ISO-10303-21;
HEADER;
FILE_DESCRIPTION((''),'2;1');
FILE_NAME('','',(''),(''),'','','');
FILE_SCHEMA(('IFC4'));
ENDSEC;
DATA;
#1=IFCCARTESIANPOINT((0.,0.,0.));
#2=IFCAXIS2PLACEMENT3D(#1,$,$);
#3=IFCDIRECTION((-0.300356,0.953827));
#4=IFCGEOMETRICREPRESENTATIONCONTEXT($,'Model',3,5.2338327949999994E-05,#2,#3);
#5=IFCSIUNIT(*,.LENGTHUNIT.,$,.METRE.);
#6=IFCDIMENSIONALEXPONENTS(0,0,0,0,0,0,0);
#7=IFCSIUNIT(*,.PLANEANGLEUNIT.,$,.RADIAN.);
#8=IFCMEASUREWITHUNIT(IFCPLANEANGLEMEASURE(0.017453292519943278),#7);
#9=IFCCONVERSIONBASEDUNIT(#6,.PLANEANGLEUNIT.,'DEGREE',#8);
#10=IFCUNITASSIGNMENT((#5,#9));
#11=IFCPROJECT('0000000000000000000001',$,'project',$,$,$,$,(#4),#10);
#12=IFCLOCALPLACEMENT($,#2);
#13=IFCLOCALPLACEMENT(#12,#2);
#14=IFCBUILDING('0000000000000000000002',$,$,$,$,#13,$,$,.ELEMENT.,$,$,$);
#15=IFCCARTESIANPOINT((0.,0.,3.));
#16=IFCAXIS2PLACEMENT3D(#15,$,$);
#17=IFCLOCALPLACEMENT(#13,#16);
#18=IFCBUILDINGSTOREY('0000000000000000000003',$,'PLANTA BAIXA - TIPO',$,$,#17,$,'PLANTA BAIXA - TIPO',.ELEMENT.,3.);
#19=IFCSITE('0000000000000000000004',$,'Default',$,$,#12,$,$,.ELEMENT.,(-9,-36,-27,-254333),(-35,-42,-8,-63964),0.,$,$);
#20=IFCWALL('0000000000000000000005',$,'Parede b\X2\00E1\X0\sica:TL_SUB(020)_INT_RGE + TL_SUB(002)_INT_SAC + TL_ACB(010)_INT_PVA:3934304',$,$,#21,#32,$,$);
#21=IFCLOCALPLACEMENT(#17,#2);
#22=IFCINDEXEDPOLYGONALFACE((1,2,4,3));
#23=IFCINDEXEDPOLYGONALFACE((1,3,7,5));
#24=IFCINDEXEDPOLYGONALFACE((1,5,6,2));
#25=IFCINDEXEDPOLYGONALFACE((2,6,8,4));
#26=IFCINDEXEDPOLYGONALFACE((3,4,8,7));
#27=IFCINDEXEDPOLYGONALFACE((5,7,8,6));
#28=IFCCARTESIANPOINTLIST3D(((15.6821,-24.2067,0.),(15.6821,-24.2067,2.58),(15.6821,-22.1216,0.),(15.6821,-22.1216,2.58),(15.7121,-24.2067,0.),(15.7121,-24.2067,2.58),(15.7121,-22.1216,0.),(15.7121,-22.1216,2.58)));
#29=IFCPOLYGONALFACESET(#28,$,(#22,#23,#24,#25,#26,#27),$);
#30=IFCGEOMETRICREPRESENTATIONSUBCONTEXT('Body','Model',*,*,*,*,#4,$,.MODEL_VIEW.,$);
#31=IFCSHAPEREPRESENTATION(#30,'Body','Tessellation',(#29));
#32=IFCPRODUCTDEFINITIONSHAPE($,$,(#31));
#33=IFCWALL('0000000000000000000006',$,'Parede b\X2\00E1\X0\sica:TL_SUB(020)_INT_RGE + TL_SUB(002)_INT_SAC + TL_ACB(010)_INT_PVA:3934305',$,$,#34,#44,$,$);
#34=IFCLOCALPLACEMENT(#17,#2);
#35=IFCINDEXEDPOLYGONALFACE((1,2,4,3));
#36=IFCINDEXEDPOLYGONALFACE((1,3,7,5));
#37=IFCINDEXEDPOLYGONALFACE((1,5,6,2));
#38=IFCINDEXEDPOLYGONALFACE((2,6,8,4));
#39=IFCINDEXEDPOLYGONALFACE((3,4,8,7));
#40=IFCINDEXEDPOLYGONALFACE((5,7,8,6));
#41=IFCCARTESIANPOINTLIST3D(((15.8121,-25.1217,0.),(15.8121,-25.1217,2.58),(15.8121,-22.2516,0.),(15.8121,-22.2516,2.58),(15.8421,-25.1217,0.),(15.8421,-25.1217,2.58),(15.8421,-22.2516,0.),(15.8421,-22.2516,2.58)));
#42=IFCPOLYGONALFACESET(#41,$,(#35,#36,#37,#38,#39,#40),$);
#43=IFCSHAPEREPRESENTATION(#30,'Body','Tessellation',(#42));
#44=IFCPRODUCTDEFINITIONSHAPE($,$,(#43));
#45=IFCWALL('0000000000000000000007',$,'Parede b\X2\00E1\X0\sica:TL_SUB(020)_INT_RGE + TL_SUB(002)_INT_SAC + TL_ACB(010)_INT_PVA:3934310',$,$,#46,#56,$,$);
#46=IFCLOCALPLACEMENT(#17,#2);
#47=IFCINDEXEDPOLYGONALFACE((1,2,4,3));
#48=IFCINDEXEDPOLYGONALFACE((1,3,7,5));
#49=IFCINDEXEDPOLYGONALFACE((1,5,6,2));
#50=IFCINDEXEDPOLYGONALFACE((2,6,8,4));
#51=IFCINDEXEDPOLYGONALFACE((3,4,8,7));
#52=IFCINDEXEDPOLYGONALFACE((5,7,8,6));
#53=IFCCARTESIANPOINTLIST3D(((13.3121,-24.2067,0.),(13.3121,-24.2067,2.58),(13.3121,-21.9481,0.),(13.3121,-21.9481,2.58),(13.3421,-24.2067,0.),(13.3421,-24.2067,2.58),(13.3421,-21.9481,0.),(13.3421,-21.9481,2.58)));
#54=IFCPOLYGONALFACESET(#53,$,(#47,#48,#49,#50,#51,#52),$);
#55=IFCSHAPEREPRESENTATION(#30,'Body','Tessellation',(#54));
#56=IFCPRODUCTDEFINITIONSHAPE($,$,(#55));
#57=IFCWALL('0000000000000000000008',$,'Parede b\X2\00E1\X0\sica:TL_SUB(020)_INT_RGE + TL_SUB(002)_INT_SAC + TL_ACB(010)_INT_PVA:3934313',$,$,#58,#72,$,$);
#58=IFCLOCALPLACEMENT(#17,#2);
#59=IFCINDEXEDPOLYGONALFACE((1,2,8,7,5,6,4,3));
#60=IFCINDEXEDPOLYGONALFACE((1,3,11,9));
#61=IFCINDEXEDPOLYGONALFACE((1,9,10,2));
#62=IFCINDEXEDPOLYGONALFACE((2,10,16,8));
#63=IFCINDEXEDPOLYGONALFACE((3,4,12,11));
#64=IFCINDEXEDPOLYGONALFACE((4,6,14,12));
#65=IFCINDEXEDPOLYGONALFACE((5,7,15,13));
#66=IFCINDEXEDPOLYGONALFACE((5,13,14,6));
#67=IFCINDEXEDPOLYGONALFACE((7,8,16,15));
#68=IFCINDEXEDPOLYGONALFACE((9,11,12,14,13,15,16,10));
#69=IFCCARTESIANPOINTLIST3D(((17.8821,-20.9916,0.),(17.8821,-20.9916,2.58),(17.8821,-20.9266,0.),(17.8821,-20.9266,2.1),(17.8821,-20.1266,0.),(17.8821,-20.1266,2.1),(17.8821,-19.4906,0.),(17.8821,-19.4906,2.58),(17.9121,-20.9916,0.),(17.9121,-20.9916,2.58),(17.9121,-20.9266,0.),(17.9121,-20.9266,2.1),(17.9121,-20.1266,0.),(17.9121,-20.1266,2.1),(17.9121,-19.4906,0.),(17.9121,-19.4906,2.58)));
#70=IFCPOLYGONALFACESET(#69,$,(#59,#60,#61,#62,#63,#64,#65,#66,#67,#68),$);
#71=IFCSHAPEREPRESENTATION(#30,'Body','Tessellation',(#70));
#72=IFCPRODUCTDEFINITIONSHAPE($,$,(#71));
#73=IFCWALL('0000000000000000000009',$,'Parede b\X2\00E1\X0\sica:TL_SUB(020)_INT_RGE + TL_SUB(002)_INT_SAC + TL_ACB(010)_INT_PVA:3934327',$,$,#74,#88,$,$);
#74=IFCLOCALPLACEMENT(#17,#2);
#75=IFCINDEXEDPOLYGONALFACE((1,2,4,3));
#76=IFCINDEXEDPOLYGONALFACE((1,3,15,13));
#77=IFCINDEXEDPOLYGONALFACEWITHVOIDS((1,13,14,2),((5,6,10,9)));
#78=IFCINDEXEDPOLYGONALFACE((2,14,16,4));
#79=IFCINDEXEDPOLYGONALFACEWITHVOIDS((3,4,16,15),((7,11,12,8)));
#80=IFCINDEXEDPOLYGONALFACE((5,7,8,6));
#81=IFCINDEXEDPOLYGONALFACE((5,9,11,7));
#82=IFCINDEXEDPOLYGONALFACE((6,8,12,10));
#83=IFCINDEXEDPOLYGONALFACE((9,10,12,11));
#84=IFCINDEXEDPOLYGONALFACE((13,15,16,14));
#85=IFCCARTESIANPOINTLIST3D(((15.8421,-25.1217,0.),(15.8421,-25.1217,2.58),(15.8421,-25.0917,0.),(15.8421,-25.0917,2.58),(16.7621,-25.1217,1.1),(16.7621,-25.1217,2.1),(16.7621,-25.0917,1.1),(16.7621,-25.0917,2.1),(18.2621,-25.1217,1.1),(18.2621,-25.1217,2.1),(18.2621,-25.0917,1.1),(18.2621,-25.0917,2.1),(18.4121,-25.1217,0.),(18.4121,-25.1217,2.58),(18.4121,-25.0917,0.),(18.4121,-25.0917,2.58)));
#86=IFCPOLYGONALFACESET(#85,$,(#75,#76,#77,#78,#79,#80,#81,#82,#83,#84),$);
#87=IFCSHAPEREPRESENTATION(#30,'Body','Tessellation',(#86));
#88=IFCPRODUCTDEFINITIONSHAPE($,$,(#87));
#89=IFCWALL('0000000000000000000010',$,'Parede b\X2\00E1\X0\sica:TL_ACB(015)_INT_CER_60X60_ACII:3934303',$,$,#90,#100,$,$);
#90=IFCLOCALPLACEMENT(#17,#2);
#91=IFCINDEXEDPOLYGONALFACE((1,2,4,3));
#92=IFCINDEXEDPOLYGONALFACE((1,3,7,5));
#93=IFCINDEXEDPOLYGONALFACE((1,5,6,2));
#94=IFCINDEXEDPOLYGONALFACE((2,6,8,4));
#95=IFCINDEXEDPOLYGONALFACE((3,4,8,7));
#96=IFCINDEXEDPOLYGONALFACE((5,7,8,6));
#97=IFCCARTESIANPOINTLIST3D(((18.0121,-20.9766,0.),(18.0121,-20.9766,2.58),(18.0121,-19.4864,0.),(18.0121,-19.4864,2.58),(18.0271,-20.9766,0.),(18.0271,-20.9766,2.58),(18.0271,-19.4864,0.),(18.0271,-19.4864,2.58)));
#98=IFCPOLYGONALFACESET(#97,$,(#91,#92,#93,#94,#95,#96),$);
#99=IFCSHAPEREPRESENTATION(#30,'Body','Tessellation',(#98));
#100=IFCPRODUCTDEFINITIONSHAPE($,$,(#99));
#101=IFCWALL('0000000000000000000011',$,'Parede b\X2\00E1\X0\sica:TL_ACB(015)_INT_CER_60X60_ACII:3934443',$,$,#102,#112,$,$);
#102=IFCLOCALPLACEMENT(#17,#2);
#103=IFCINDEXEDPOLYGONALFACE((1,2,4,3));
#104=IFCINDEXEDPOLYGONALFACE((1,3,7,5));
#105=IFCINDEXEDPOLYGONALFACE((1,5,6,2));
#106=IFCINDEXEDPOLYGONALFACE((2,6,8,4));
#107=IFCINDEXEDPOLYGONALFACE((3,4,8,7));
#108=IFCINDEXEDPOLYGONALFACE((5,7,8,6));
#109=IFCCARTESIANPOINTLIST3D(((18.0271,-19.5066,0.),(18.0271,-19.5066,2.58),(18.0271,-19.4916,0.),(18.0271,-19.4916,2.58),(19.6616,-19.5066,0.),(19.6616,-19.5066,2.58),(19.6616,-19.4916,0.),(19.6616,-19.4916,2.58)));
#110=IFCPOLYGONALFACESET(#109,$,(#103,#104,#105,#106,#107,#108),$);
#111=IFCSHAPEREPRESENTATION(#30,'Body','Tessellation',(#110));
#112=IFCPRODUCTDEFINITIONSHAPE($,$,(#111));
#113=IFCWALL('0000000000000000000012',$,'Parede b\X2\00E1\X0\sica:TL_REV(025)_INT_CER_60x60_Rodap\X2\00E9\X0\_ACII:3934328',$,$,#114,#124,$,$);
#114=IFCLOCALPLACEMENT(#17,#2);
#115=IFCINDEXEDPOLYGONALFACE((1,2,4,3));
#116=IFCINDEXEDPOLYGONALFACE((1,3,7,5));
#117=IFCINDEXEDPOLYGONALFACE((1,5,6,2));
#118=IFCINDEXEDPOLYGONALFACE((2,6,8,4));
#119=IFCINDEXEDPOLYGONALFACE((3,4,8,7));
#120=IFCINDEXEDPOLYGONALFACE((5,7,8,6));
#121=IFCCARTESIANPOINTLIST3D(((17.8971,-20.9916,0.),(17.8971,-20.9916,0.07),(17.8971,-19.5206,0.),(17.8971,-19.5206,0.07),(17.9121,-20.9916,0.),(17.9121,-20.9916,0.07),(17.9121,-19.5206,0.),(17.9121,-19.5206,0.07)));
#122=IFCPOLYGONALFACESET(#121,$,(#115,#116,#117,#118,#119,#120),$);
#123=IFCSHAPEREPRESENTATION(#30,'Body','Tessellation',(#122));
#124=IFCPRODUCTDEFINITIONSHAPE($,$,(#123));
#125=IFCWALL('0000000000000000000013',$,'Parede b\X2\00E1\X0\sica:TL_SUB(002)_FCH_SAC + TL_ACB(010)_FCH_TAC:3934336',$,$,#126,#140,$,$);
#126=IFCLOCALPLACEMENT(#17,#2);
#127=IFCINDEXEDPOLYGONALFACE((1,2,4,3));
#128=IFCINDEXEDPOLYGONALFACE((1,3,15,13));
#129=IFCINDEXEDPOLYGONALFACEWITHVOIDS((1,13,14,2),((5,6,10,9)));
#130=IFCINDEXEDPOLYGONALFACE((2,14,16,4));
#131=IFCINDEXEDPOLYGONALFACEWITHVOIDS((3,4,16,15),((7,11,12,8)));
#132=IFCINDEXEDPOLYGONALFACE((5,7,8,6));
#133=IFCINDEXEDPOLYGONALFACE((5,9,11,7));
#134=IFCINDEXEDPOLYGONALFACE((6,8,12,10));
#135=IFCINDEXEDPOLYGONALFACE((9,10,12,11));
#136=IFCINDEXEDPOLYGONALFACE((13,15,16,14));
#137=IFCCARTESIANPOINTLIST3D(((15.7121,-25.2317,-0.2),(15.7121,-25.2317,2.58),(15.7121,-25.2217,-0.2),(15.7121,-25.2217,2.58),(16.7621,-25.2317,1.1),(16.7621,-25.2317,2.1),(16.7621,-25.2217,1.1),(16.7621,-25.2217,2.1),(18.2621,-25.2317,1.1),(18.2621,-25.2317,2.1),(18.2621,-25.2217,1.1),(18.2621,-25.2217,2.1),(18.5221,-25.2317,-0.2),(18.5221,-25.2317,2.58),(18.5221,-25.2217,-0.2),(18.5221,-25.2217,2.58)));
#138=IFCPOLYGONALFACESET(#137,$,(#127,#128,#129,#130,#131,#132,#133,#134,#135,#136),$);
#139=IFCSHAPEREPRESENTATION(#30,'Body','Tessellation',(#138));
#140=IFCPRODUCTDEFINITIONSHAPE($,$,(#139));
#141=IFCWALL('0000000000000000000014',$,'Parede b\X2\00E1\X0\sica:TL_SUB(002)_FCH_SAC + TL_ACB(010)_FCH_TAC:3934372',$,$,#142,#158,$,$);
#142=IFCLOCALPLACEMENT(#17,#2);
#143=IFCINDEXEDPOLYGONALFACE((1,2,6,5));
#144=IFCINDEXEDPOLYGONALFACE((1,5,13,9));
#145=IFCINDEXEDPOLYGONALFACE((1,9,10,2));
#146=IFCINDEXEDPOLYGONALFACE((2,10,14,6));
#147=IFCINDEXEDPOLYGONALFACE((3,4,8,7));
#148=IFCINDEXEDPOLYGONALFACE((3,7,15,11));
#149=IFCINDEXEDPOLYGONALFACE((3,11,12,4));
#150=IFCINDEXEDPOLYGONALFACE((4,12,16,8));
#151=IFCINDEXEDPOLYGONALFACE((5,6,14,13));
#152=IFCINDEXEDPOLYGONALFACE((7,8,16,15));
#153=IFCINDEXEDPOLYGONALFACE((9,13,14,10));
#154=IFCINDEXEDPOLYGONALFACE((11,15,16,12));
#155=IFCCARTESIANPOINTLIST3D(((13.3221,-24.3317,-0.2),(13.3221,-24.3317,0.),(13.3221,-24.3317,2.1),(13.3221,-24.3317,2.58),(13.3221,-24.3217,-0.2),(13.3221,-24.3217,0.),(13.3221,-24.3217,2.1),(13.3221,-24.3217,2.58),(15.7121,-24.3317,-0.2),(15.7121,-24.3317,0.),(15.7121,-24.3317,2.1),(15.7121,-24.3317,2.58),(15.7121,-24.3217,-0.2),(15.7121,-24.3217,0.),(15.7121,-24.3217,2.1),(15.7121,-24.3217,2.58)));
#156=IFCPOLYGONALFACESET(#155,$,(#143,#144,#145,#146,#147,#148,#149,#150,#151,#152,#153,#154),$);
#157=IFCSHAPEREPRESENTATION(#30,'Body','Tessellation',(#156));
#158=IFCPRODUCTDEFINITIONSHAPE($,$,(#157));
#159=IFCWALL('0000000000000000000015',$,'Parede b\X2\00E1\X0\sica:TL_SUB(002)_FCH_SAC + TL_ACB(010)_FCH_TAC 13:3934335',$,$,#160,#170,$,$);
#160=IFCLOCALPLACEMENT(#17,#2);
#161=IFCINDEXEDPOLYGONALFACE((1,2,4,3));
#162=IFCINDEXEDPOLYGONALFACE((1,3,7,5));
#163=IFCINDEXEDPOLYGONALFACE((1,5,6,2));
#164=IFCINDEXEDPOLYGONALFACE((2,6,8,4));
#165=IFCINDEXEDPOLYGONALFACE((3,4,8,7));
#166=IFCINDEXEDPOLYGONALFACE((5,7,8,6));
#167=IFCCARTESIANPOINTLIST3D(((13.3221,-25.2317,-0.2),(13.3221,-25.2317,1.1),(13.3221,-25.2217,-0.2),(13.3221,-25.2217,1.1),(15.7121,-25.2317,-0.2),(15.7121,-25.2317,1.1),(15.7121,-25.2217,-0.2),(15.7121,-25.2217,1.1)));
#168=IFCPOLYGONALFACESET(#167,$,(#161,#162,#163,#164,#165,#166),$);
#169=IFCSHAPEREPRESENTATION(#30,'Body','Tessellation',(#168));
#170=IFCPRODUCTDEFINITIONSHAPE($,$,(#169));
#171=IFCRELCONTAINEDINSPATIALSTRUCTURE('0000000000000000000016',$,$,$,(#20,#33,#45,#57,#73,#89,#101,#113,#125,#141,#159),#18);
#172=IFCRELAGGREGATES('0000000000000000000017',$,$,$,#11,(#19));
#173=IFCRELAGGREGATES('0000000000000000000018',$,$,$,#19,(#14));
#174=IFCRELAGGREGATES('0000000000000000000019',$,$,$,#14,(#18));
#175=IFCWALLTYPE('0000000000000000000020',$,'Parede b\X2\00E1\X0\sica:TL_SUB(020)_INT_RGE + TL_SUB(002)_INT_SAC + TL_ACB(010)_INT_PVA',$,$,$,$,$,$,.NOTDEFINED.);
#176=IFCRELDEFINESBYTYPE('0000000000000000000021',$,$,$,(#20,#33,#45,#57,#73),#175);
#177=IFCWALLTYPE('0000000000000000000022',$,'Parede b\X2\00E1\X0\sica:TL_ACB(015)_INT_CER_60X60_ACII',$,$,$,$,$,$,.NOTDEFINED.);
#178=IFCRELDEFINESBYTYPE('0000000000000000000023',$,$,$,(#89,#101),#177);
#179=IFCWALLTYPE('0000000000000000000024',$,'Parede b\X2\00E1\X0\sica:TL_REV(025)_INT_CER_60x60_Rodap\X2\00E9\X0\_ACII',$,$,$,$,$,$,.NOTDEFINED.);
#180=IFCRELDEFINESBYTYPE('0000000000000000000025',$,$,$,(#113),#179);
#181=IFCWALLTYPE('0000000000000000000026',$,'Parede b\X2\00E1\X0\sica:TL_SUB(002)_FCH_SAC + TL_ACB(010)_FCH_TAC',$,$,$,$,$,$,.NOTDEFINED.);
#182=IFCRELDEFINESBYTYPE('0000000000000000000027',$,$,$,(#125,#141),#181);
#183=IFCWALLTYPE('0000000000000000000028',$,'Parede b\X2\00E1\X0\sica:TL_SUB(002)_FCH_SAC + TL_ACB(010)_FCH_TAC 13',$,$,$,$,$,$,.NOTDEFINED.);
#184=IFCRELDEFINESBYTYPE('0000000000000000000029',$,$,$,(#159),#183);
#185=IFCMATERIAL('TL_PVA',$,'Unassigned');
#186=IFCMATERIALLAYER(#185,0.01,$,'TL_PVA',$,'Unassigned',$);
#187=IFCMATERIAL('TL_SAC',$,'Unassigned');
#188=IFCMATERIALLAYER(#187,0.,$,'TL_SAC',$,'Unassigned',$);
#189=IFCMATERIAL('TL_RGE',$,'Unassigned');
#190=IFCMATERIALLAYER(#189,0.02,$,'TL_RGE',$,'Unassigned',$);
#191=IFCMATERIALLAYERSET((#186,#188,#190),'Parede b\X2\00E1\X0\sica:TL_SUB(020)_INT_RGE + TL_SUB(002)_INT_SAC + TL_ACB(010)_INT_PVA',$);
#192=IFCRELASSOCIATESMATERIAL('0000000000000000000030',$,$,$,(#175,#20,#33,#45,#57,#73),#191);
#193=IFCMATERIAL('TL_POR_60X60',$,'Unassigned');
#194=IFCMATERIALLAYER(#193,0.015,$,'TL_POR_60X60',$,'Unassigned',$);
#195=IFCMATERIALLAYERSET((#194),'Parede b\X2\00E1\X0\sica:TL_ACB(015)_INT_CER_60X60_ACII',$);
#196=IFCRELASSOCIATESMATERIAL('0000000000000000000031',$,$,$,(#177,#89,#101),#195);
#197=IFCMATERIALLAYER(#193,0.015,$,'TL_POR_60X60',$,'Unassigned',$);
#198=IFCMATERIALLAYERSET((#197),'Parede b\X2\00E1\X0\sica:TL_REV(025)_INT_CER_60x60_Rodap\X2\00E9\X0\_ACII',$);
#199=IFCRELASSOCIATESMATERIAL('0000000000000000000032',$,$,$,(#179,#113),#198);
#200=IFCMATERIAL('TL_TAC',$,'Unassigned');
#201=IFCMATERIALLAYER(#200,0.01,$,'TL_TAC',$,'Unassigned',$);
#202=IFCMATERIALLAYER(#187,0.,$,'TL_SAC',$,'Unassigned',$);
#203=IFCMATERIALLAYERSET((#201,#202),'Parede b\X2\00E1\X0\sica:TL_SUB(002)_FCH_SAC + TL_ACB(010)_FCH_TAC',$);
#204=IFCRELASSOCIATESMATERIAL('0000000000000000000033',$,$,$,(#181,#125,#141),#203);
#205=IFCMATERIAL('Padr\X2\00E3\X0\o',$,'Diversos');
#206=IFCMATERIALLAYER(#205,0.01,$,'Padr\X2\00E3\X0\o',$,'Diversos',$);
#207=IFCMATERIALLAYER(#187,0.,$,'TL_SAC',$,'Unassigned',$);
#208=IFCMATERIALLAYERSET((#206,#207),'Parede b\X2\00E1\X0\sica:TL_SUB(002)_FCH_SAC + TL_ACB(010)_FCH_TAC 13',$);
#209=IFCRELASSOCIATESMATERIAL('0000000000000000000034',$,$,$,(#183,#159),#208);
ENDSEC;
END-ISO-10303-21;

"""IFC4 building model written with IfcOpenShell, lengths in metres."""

from ifc_helpers import new_model, entity, si_unit, converted_unit, direction, frame, frame_2d, origin, place, context, subcontext, project, spatial, rectangle, extrude, material, layer, layer_set, layer_usage, type_object, element, save


model = new_model("IFC4")

# Units and contexts
model_context = context("Model", 3, precision=5.2338327949999994e-05, world=origin(), true_north=direction((-0.300356, 0.953827)))
body_context = subcontext(model_context, "Body", "Model", "MODEL_VIEW")
ifc_project = project(units=[si_unit("LENGTHUNIT", "METRE"), converted_unit("PLANEANGLEUNIT", "DEGREE", entity("IfcPlaneAngleMeasure", 0.017453292519943278), si_unit("PLANEANGLEUNIT", "RADIAN"), dimensions=[0, 0, 0, 0, 0, 0, 0])], contexts=[model_context])

# Site, building, storey
site_placement = place(None, origin())
site = spatial("IfcSite", under=ifc_project, at=site_placement, Name="Default", CompositionType="ELEMENT", RefLatitude=(-9, -36, -27, -254333), RefLongitude=(-35, -42, -8, -63964), RefElevation=0.0)
building_placement = place(site_placement, origin())
building = spatial("IfcBuilding", under=site, at=building_placement, CompositionType="ELEMENT")
storey_placement = place(building_placement, frame((0.0, 0.0, 3.0)))
storey = spatial("IfcBuildingStorey", under=building, at=storey_placement, Name="PLANTA BAIXA - TIPO", LongName="PLANTA BAIXA - TIPO", CompositionType="ELEMENT", Elevation=3.0)

# Shared definitions
ifc_material_1 = material(Name="TL_PVA", Category="Unassigned")
ifc_layer_1 = layer(ifc_material_1, 0.01, Name="TL_PVA", Category="Unassigned")
ifc_material_2 = material(Name="TL_SAC", Category="Unassigned")
ifc_layer_2 = layer(ifc_material_2, 0.0, Name="TL_SAC", Category="Unassigned")
ifc_material_3 = material(Name="TL_RGE", Category="Unassigned")
ifc_layer_3 = layer(ifc_material_3, 0.02, Name="TL_RGE", Category="Unassigned")
ifc_layer_set_1 = layer_set([ifc_layer_1, ifc_layer_2, ifc_layer_3], Name="Parede básica:TL_SUB(020)_INT_RGE + TL_SUB(002)_INT_SAC + TL_ACB(010)_INT_PVA")
wall_type_1 = type_object("IfcWallType", Name="Parede básica:TL_SUB(020)_INT_RGE + TL_SUB(002)_INT_SAC + TL_ACB(010)_INT_PVA", PredefinedType="NOTDEFINED", material=ifc_layer_set_1)

# Walls
ifc_layer_usage_1 = layer_usage(ifc_layer_set_1, "AXIS2", "NEGATIVE", 0.015)
wall_1_placement = place(storey_placement, frame((15.6971, -24.2067, 0.0), z_axis=(0.0, 0.0, 1.0), x_axis=(0.0, 1.0, 0.0)))
element("IfcWall", 1, at=wall_1_placement, inside=storey, type_object=wall_type_1, material=ifc_layer_usage_1, Name="Parede básica:TL_SUB(020)_INT_RGE + TL_SUB(002)_INT_SAC + TL_ACB(010)_INT_PVA:3934304", context=body_context, shape_type="SweptSolid", body=[
    extrude(rectangle(XDim=2.0851, YDim=0.03, at=frame_2d((1.0426, 0.0), x_axis=(-1.0, 0.0))), origin(), (0.0, 0.0, 1.0), 2.58),
])
ifc_layer_usage_2 = layer_usage(ifc_layer_set_1, "AXIS2", "NEGATIVE", 0.015)
wall_2_placement = place(storey_placement, frame((15.8271, -22.2516, 0.0), z_axis=(0.0, 0.0, 1.0), x_axis=(0.0, -1.0, 0.0)))
element("IfcWall", 2, at=wall_2_placement, inside=storey, type_object=wall_type_1, material=ifc_layer_usage_2, Name="Parede básica:TL_SUB(020)_INT_RGE + TL_SUB(002)_INT_SAC + TL_ACB(010)_INT_PVA:3934305", context=body_context, shape_type="SweptSolid", body=[
    extrude(rectangle(XDim=2.8701, YDim=0.03, at=frame_2d((1.4351, 0.0), x_axis=(-1.0, 0.0))), origin(), (0.0, 0.0, 1.0), 2.58),
])
ifc_layer_usage_3 = layer_usage(ifc_layer_set_1, "AXIS2", "NEGATIVE", 0.015)
wall_3_placement = place(storey_placement, frame((13.3271, -21.9481, 0.0), z_axis=(0.0, 0.0, 1.0), x_axis=(0.0, -1.0, 0.0)))
element("IfcWall", 3, at=wall_3_placement, inside=storey, type_object=wall_type_1, material=ifc_layer_usage_3, Name="Parede básica:TL_SUB(020)_INT_RGE + TL_SUB(002)_INT_SAC + TL_ACB(010)_INT_PVA:3934310", context=body_context, shape_type="SweptSolid", body=[
    extrude(rectangle(XDim=2.2587, YDim=0.03, at=frame_2d((1.1293, 0.0), x_axis=(-1.0, 0.0))), origin(), (0.0, 0.0, 1.0), 2.58),
])

# Walls, openings
ifc_layer_usage_4 = layer_usage(ifc_layer_set_1, "AXIS2", "NEGATIVE", 0.015)
wall_4_placement = place(storey_placement, frame((17.8971, -20.9916, 0.0), z_axis=(0.0, 0.0, 1.0), x_axis=(0.0, 1.0, 0.0)))
wall_4 = element("IfcWall", 4, at=wall_4_placement, inside=storey, type_object=wall_type_1, material=ifc_layer_usage_4, Name="Parede básica:TL_SUB(020)_INT_RGE + TL_SUB(002)_INT_SAC + TL_ACB(010)_INT_PVA:3934313", context=body_context, shape_type="SweptSolid", body=[
    extrude(rectangle(XDim=1.501, YDim=0.03, at=frame_2d((0.7505, 0.0), x_axis=(-1.0, 0.0))), origin(), (0.0, 0.0, 1.0), 2.58),
])
opening_1_placement = place(wall_4_placement, frame((0.865, 0.015, 0.0)))
element("IfcOpeningElement", 5, at=opening_1_placement, cuts=wall_4, PredefinedType="OPENING", context=body_context, shape_type="SweptSolid", body=[
    extrude(rectangle(XDim=2.1, YDim=0.8, at=frame_2d((1.05, 0.4), x_axis=(1.0, 0.0))), frame((0.0, 0.0, 0.0), z_axis=(0.0, -1.0, 0.0), x_axis=(0.0, 0.0, 1.0)), (0.0, 0.0, 1.0), 0.03),
])
ifc_layer_usage_5 = layer_usage(ifc_layer_set_1, "AXIS2", "NEGATIVE", 0.015)
wall_5_placement = place(storey_placement, frame((15.8421, -25.1067, 0.0)))
wall_5 = element("IfcWall", 6, at=wall_5_placement, inside=storey, type_object=wall_type_1, material=ifc_layer_usage_5, Name="Parede básica:TL_SUB(020)_INT_RGE + TL_SUB(002)_INT_SAC + TL_ACB(010)_INT_PVA:3934327", context=body_context, shape_type="SweptSolid", body=[
    extrude(rectangle(XDim=2.57, YDim=0.03, at=frame_2d((1.285, 0.0), x_axis=(-1.0, 0.0))), origin(), (0.0, 0.0, 1.0), 2.58),
])
opening_2_placement = place(wall_5_placement, frame((-15.8421, 25.1067, 1.1)))
element("IfcOpeningElement", 7, at=opening_2_placement, cuts=wall_5, PredefinedType="OPENING", context=body_context, shape_type="SweptSolid", body=[
    extrude(rectangle(XDim=1.0, YDim=1.5, at=frame_2d((0.0, 0.0), x_axis=(0.0, 1.0))), frame((17.5121, -26.6457, 0.5), z_axis=(0.0, 1.0, 0.0), x_axis=(1.0, 0.0, 0.0)), (0.0, 0.0, 1.0), 3.048),
])

# Walls
ifc_material_4 = material(Name="TL_POR_60X60", Category="Unassigned")
ifc_layer_4 = layer(ifc_material_4, 0.015, Name="TL_POR_60X60", Category="Unassigned")
ifc_layer_set_2 = layer_set([ifc_layer_4], Name="Parede básica:TL_ACB(015)_INT_CER_60X60_ACII")
ifc_layer_usage_6 = layer_usage(ifc_layer_set_2, "AXIS2", "NEGATIVE", 0.0075)
wall_type_2 = type_object("IfcWallType", Name="Parede básica:TL_ACB(015)_INT_CER_60X60_ACII", PredefinedType="NOTDEFINED", material=ifc_layer_set_2)
wall_6_placement = place(storey_placement, frame((18.0196, -19.4864, 0.0), z_axis=(0.0, 0.0, 1.0), x_axis=(0.0, -1.0, 0.0)))
element("IfcWall", 8, at=wall_6_placement, inside=storey, type_object=wall_type_2, material=ifc_layer_usage_6, Name="Parede básica:TL_ACB(015)_INT_CER_60X60_ACII:3934303", context=body_context, shape_type="SweptSolid", body=[
    extrude(rectangle(XDim=1.4902, YDim=0.015, at=frame_2d((0.7451, 0.0), x_axis=(-1.0, 0.0))), origin(), (0.0, 0.0, 1.0), 2.58),
])
ifc_layer_usage_7 = layer_usage(ifc_layer_set_2, "AXIS2", "POSITIVE", -0.0075)
wall_7_placement = place(storey_placement, frame((18.0271, -19.4991, 0.0)))
element("IfcWall", 9, at=wall_7_placement, inside=storey, type_object=wall_type_2, material=ifc_layer_usage_7, Name="Parede básica:TL_ACB(015)_INT_CER_60X60_ACII:3934443", context=body_context, shape_type="SweptSolid", body=[
    extrude(rectangle(XDim=1.6345, YDim=0.015, at=frame_2d((0.8172, 0.0), x_axis=(-1.0, 0.0))), origin(), (0.0, 0.0, 1.0), 2.58),
])
ifc_layer_5 = layer(ifc_material_4, 0.015, Name="TL_POR_60X60", Category="Unassigned")
ifc_layer_set_3 = layer_set([ifc_layer_5], Name="Parede básica:TL_REV(025)_INT_CER_60x60_Rodapé_ACII")
ifc_layer_usage_8 = layer_usage(ifc_layer_set_3, "AXIS2", "POSITIVE", -0.0075)
wall_type_3 = type_object("IfcWallType", Name="Parede básica:TL_REV(025)_INT_CER_60x60_Rodapé_ACII", PredefinedType="NOTDEFINED", material=ifc_layer_set_3)
wall_8_placement = place(storey_placement, frame((17.9046, -19.5206, 0.0), z_axis=(0.0, 0.0, 1.0), x_axis=(0.0, -1.0, 0.0)))
element("IfcWall", 10, at=wall_8_placement, inside=storey, type_object=wall_type_3, material=ifc_layer_usage_8, Name="Parede básica:TL_REV(025)_INT_CER_60x60_Rodapé_ACII:3934328", context=body_context, shape_type="SweptSolid", body=[
    extrude(rectangle(XDim=1.471, YDim=0.015, at=frame_2d((0.7355, 0.0), x_axis=(-1.0, 0.0))), origin(), (0.0, 0.0, 1.0), 0.07),
])

# Walls, openings
ifc_material_5 = material(Name="TL_TAC", Category="Unassigned")
ifc_layer_6 = layer(ifc_material_5, 0.01, Name="TL_TAC", Category="Unassigned")
ifc_layer_7 = layer(ifc_material_2, 0.0, Name="TL_SAC", Category="Unassigned")
ifc_layer_set_4 = layer_set([ifc_layer_6, ifc_layer_7], Name="Parede básica:TL_SUB(002)_FCH_SAC + TL_ACB(010)_FCH_TAC")
ifc_layer_usage_9 = layer_usage(ifc_layer_set_4, "AXIS2", "POSITIVE", -0.005)
wall_type_4 = type_object("IfcWallType", Name="Parede básica:TL_SUB(002)_FCH_SAC + TL_ACB(010)_FCH_TAC", PredefinedType="NOTDEFINED", material=ifc_layer_set_4)
wall_9_placement = place(storey_placement, frame((15.7121, -25.2267, -0.2)))
wall_9 = element("IfcWall", 11, at=wall_9_placement, inside=storey, type_object=wall_type_4, material=ifc_layer_usage_9, Name="Parede básica:TL_SUB(002)_FCH_SAC + TL_ACB(010)_FCH_TAC:3934336", context=body_context, shape_type="SweptSolid", body=[
    extrude(rectangle(XDim=2.81, YDim=0.01, at=frame_2d((1.405, 0.0), x_axis=(-1.0, 0.0))), origin(), (0.0, 0.0, 1.0), 2.78),
])
opening_3_placement = place(wall_9_placement, frame((-15.7121, 25.2267, 1.3)))
element("IfcOpeningElement", 12, at=opening_3_placement, cuts=wall_9, PredefinedType="OPENING", context=body_context, shape_type="SweptSolid", body=[
    extrude(rectangle(XDim=1.0, YDim=1.5, at=frame_2d((0.0, 0.0), x_axis=(0.0, 1.0))), frame((17.5121, -26.6457, 0.5), z_axis=(0.0, 1.0, 0.0), x_axis=(1.0, 0.0, 0.0)), (0.0, 0.0, 1.0), 3.048),
])
ifc_layer_usage_10 = layer_usage(ifc_layer_set_4, "AXIS2", "POSITIVE", -0.005)
wall_10_placement = place(storey_placement, frame((13.3221, -24.3267, -0.2)))
wall_10 = element("IfcWall", 13, at=wall_10_placement, inside=storey, type_object=wall_type_4, material=ifc_layer_usage_10, Name="Parede básica:TL_SUB(002)_FCH_SAC + TL_ACB(010)_FCH_TAC:3934372", context=body_context, shape_type="SweptSolid", body=[
    extrude(rectangle(XDim=2.39, YDim=0.01, at=frame_2d((1.195, 0.0), x_axis=(-1.0, 0.0))), origin(), (0.0, 0.0, 1.0), 2.78),
])
opening_4_placement = place(wall_10_placement, frame((-13.3221, 24.3267, 0.2)))
element("IfcOpeningElement", 14, at=opening_4_placement, cuts=wall_10, PredefinedType="OPENING", context=body_context, shape_type="SweptSolid", body=[
    extrude(rectangle(XDim=2.1, YDim=2.4, at=frame_2d((0.0, 0.0), x_axis=(0.0, 1.0))), frame((14.5121, -25.8457, 1.05), z_axis=(0.0, 1.0, 0.0), x_axis=(-1.0, 0.0, 0.0)), (0.0, 0.0, 1.0), 3.048),
])

# Wall
ifc_material_6 = material(Name="Padrão", Category="Diversos")
ifc_layer_8 = layer(ifc_material_6, 0.01, Name="Padrão", Category="Diversos")
ifc_layer_9 = layer(ifc_material_2, 0.0, Name="TL_SAC", Category="Unassigned")
ifc_layer_set_5 = layer_set([ifc_layer_8, ifc_layer_9], Name="Parede básica:TL_SUB(002)_FCH_SAC + TL_ACB(010)_FCH_TAC 13")
ifc_layer_usage_11 = layer_usage(ifc_layer_set_5, "AXIS2", "NEGATIVE", 0.005)
wall_type_5 = type_object("IfcWallType", Name="Parede básica:TL_SUB(002)_FCH_SAC + TL_ACB(010)_FCH_TAC 13", PredefinedType="NOTDEFINED", material=ifc_layer_set_5)
wall_11_placement = place(storey_placement, frame((13.3221, -25.2267, -0.2)))
element("IfcWall", 15, at=wall_11_placement, inside=storey, type_object=wall_type_5, material=ifc_layer_usage_11, Name="Parede básica:TL_SUB(002)_FCH_SAC + TL_ACB(010)_FCH_TAC 13:3934335", context=body_context, shape_type="SweptSolid", body=[
    extrude(rectangle(XDim=2.39, YDim=0.01, at=frame_2d((1.195, 0.0), x_axis=(-1.0, 0.0))), origin(), (0.0, 0.0, 1.0), 1.3),
])

save(model, "model.ifc")
